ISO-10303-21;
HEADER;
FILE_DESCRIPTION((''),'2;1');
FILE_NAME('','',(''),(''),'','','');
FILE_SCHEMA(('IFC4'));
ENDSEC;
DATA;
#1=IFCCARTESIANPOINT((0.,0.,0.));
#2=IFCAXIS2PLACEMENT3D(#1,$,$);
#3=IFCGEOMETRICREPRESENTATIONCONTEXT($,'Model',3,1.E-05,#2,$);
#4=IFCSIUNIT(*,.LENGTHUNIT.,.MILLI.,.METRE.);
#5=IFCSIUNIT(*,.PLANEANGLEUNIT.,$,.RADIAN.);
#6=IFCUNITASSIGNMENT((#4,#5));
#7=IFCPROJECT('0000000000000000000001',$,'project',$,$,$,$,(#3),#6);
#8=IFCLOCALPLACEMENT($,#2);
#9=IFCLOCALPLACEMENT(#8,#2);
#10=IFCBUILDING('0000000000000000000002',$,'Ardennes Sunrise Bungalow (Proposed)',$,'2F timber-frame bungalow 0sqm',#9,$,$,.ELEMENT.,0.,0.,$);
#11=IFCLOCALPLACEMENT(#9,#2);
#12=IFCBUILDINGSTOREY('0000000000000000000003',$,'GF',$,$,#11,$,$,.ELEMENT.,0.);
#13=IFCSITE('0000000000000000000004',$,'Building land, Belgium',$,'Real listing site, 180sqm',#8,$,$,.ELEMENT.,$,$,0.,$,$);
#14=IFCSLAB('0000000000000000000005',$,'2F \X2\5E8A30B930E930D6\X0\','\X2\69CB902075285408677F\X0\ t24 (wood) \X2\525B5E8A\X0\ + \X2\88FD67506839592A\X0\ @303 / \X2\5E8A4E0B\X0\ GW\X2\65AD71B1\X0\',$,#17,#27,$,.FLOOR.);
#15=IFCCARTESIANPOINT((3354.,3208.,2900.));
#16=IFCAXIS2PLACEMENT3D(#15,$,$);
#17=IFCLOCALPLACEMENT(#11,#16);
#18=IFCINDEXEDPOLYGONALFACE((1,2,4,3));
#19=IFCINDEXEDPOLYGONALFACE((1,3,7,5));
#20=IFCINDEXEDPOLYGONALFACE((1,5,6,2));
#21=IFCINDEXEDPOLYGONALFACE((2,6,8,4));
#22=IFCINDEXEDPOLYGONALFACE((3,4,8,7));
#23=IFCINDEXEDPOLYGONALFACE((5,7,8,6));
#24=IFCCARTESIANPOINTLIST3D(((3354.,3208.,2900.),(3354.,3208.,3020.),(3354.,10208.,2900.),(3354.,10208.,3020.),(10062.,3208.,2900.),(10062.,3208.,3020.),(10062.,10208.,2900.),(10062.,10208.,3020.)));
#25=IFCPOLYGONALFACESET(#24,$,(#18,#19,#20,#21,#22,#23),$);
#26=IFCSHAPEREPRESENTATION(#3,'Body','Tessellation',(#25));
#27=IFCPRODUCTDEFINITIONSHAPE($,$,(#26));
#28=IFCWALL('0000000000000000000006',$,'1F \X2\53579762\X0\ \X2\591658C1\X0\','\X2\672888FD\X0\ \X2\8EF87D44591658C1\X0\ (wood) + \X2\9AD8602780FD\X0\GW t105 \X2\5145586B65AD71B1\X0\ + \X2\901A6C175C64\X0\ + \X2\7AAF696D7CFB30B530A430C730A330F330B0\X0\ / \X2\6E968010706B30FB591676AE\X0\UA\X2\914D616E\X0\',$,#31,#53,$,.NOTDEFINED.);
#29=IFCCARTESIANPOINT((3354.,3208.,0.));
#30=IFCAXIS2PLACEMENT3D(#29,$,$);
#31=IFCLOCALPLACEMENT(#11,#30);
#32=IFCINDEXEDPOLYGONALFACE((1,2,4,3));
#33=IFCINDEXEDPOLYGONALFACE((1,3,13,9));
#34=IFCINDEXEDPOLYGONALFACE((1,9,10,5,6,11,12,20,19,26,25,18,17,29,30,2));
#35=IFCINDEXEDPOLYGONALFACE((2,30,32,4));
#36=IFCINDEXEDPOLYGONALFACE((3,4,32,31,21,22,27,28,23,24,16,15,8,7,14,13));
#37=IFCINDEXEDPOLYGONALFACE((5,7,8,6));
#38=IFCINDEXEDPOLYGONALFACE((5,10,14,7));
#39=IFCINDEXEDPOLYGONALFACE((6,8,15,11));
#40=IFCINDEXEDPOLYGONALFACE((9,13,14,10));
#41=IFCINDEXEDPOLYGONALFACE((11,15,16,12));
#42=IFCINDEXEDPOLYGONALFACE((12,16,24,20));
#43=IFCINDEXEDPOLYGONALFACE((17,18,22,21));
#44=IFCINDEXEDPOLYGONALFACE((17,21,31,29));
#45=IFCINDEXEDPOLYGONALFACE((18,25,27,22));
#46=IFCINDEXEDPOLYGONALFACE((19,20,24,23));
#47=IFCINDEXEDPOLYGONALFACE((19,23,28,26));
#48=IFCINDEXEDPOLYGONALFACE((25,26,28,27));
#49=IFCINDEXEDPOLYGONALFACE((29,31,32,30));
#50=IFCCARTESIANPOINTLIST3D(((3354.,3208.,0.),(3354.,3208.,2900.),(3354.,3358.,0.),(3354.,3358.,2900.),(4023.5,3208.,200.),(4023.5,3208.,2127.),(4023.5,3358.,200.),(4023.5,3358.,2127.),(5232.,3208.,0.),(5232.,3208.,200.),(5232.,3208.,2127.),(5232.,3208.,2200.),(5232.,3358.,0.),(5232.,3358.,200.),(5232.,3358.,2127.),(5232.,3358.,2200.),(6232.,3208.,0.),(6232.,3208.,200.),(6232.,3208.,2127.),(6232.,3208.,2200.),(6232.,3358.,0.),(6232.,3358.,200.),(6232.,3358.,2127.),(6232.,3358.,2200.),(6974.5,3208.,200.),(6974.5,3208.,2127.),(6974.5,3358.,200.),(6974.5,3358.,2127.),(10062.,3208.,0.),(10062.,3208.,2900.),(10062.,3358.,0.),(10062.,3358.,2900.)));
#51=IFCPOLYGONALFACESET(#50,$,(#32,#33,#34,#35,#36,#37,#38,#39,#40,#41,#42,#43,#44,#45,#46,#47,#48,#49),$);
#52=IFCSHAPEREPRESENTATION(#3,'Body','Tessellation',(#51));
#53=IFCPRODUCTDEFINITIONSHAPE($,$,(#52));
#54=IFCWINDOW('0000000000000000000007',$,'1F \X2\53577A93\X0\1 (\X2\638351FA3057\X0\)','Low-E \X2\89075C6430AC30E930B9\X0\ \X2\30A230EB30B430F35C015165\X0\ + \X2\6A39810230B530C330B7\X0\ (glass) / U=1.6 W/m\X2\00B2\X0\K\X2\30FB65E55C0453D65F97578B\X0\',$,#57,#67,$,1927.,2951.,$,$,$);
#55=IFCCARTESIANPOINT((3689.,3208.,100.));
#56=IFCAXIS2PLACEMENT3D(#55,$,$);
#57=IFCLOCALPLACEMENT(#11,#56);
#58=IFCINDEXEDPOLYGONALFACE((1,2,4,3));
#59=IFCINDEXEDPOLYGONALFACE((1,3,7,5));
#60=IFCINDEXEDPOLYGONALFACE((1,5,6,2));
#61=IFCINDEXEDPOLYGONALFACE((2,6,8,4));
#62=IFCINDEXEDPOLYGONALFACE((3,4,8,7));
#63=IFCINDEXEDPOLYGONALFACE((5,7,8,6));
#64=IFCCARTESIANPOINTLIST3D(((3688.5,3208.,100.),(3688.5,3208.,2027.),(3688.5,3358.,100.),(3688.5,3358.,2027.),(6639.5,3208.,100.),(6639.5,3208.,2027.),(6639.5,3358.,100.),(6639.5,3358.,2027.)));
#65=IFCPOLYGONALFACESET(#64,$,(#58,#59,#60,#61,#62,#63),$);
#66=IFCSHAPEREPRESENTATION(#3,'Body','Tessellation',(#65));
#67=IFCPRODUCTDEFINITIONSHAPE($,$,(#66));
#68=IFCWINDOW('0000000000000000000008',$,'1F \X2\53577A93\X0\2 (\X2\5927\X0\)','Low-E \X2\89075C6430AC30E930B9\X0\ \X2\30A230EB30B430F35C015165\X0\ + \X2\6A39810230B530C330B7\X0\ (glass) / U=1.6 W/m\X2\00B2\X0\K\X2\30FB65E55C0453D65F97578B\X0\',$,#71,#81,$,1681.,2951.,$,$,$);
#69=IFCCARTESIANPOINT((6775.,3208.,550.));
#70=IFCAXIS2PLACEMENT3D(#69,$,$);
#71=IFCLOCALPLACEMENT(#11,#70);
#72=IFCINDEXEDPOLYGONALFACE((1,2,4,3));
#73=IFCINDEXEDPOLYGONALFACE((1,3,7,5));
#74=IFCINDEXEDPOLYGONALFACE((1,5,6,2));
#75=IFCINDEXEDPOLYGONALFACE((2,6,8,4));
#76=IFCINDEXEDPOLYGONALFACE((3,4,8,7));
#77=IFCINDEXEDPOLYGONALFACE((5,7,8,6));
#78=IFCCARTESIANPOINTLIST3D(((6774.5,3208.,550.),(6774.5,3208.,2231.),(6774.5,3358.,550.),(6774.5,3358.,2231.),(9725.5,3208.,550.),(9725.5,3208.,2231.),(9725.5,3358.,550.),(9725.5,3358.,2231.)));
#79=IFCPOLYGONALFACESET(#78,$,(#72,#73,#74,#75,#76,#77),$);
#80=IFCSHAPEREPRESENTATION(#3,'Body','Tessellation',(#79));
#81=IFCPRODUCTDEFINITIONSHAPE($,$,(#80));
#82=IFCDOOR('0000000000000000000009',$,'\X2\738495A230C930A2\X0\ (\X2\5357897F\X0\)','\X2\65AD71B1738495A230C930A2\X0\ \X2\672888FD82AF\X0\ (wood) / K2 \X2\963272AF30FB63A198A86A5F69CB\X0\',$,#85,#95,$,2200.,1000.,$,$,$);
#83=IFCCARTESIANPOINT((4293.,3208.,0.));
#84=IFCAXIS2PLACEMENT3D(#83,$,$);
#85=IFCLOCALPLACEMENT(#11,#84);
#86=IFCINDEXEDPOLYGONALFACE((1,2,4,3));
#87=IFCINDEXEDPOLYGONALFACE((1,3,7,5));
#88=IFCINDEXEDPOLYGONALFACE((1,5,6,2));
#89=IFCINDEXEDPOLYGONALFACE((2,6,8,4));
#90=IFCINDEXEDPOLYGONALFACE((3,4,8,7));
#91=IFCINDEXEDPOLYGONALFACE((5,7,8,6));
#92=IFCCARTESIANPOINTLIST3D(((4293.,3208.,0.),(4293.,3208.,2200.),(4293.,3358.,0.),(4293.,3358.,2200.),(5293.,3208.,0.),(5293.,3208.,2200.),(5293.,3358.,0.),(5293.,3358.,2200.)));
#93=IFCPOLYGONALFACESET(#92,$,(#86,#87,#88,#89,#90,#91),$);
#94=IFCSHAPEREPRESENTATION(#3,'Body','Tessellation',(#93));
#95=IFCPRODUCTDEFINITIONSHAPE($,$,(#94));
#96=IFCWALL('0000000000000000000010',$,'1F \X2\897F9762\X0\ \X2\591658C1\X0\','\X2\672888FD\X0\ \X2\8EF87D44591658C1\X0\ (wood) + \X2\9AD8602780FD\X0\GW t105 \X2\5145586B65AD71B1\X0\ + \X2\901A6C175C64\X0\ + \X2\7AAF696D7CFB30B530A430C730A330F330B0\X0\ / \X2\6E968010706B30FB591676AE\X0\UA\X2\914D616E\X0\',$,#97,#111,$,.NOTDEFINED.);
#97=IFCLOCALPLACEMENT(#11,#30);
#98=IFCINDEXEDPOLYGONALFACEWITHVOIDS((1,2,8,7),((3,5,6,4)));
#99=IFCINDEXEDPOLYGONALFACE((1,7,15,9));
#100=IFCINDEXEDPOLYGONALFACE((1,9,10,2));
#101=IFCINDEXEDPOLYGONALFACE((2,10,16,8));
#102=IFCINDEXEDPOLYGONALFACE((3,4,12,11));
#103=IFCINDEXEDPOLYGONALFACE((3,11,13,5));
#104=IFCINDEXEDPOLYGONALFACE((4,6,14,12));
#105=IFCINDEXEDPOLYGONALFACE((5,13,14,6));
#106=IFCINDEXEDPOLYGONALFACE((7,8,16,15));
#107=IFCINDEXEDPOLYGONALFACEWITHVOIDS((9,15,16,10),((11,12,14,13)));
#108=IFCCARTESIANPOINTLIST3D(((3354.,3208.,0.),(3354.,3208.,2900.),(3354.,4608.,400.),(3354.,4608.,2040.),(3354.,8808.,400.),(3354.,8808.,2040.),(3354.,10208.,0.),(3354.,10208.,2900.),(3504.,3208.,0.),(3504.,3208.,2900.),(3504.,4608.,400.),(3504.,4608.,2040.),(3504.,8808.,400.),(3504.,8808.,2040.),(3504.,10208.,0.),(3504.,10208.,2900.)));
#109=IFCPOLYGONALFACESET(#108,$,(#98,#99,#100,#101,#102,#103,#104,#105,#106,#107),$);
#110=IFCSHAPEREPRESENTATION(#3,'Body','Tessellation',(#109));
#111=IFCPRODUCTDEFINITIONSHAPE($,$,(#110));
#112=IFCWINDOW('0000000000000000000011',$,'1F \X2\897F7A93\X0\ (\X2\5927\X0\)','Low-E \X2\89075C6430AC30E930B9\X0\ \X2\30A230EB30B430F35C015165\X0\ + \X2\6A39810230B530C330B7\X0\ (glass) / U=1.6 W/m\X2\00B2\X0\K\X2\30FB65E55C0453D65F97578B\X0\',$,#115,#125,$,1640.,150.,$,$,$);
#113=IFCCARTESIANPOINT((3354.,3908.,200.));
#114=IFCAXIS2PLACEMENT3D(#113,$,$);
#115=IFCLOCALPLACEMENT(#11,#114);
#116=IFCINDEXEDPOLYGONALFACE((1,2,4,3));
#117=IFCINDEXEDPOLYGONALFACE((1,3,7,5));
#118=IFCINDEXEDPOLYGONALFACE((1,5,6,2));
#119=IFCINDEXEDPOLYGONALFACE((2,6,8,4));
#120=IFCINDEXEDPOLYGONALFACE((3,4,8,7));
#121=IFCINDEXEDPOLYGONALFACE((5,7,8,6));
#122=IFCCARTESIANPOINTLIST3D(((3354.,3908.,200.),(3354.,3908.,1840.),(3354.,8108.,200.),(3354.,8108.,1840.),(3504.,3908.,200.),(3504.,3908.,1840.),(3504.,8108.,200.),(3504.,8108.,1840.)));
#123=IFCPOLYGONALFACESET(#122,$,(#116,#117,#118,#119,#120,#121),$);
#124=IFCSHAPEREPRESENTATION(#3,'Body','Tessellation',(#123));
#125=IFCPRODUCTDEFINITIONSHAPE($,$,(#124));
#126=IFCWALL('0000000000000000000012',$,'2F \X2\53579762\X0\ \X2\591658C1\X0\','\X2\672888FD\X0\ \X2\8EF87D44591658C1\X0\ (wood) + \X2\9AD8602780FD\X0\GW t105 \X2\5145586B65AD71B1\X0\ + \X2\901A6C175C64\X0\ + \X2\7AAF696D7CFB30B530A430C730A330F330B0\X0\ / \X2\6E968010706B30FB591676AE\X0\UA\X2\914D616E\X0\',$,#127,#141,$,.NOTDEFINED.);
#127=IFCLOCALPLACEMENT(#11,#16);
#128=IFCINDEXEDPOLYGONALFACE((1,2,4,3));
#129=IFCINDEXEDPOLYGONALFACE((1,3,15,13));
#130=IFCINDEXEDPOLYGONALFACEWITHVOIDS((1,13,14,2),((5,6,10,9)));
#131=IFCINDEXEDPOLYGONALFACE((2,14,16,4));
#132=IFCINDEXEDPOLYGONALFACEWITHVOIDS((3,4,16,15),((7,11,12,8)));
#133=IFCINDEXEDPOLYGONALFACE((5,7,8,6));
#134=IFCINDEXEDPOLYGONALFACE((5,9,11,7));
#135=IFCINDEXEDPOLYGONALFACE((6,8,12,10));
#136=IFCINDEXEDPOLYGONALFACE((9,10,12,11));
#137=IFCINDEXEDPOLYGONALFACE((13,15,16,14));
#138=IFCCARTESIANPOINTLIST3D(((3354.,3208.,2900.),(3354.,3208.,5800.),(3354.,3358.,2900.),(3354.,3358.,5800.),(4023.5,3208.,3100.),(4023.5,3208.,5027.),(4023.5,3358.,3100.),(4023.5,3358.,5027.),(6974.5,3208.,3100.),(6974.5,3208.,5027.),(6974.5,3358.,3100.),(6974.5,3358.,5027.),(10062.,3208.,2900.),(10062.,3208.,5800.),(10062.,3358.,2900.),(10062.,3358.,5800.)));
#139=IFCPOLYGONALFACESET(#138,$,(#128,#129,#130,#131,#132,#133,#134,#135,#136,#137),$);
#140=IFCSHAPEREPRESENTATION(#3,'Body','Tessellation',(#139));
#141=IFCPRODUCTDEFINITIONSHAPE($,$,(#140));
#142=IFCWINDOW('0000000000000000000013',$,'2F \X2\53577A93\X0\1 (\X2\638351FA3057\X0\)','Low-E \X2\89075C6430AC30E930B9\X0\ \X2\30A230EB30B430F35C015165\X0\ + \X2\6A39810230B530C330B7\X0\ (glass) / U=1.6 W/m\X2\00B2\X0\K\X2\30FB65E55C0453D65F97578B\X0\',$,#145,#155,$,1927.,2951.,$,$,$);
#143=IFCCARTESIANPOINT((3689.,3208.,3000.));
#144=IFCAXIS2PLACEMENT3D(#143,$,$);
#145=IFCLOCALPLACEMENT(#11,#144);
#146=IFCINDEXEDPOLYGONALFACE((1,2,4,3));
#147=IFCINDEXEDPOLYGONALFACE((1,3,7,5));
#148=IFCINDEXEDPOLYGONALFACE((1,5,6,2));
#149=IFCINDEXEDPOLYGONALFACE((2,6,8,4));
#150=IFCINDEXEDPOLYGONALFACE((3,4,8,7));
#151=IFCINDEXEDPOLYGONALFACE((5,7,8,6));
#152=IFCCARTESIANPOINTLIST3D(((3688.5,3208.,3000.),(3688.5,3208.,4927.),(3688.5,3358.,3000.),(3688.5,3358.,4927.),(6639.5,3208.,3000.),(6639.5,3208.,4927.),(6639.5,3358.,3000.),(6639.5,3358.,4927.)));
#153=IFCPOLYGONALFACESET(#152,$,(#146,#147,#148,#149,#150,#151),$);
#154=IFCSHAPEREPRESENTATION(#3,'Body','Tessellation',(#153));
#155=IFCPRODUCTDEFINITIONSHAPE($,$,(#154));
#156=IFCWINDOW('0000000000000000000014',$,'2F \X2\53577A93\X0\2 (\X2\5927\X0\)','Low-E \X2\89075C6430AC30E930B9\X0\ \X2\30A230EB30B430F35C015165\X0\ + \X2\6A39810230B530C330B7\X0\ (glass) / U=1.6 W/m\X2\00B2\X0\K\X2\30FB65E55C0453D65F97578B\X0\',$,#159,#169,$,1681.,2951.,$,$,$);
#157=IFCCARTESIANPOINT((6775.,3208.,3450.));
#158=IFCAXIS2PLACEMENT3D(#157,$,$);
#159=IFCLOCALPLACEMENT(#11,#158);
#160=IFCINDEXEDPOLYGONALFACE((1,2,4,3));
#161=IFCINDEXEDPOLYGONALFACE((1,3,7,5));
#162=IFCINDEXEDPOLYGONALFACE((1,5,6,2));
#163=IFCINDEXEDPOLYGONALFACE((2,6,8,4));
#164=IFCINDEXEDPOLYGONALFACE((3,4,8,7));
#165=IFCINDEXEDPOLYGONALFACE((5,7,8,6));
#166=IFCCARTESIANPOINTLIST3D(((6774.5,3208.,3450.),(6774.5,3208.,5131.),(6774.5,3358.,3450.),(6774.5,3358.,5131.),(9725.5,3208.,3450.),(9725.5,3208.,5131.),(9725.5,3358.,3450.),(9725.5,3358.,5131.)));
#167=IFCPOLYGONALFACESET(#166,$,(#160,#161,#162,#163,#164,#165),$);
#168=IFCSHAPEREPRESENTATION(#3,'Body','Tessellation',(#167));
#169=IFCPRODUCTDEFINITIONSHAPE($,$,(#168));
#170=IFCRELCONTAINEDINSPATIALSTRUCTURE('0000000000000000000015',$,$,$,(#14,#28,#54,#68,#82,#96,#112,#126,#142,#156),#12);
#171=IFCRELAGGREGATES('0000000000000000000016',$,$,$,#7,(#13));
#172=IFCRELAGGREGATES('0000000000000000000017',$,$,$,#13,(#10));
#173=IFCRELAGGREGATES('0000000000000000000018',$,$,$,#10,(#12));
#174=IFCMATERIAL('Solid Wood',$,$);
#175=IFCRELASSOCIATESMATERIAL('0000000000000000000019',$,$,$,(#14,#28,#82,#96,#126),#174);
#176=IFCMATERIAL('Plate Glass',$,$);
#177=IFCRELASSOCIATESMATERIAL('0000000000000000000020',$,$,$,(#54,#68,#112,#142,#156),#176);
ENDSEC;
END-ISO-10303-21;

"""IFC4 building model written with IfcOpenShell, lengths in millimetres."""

from ifc_helpers import new_model, si_unit, frame, frame_2d, origin, place, context, project, spatial, rectangle, extrude, material, element, fill, save


model = new_model("IFC4")

# Units and contexts
model_context = context("Model", 3, precision=1e-05, world=origin())
ifc_project = project(units=[si_unit("LENGTHUNIT", "METRE", prefix="MILLI"), si_unit("PLANEANGLEUNIT", "RADIAN")], contexts=[model_context])

# Site, building, storey
site_placement = place(None, origin())
site = spatial("IfcSite", under=ifc_project, at=site_placement, Name="Building land, Belgium", ObjectType="Real listing site, 180sqm", CompositionType="ELEMENT", RefElevation=0.0)
building_placement = place(site_placement, origin())
building = spatial("IfcBuilding", under=site, at=building_placement, Name="Ardennes Sunrise Bungalow (Proposed)", ObjectType="2F timber-frame bungalow 0sqm", CompositionType="ELEMENT", ElevationOfRefHeight=0.0, ElevationOfTerrain=0.0)
storey_placement = place(building_placement, origin())
storey = spatial("IfcBuildingStorey", under=building, at=storey_placement, Name="GF", CompositionType="ELEMENT", Elevation=0.0)

# Slab
ifc_material_1 = material(Name="Solid Wood")
slab_1_placement = place(storey_placement, frame((3354.0, 3208.0, 2900.0)))
element("IfcSlab", 1, at=slab_1_placement, inside=storey, material=ifc_material_1, Name="2F 床スラブ", Description="構造用合板 t24 (wood) 剛床 + 製材根太 @303 / 床下 GW断熱", PredefinedType="FLOOR", context=model_context, shape_type="SweptSolid", body=[
    extrude(rectangle(XDim=6708.0, YDim=7000.0, at=frame_2d((3354.0, 3500.0))), frame((3354.0, 3208.0, 2900.0)), (0.0, 0.0, 1.0), 120.0),
])

# Wall, openings, windows, door
wall_1_placement = place(storey_placement, frame((3354.0, 3208.0, 0.0)))
wall_1 = element("IfcWall", 2, at=wall_1_placement, inside=storey, material=ifc_material_1, Name="1F 南面 外壁", Description="木製 軸組外壁 (wood) + 高性能GW t105 充填断熱 + 通気層 + 窯業系サイディング / 準耐火・外皮UA配慮", PredefinedType="NOTDEFINED", context=model_context, shape_type="SweptSolid", body=[
    extrude(rectangle(XDim=6708.0, YDim=150.0, at=frame_2d((3354.0, 75.0))), frame((3354.0, 3208.0, 0.0)), (0.0, 0.0, 1.0), 2900.0),
])
opening_1_placement = place(storey_placement, frame((3689.0, 3208.0, 100.0)))
opening_1 = element("IfcOpeningElement", 3, at=opening_1_placement, cuts=wall_1, PredefinedType="NOTDEFINED", context=model_context, shape_type="SweptSolid", body=[
    extrude(rectangle(XDim=2951.0, YDim=150.0, at=frame_2d((1475.0, 75.0))), frame((3689.0, 3208.0, 100.0)), (0.0, 0.0, 1.0), 1927.0),
])
opening_2_placement = place(storey_placement, frame((6775.0, 3208.0, 550.0)))
opening_2 = element("IfcOpeningElement", 4, at=opening_2_placement, cuts=wall_1, PredefinedType="NOTDEFINED", context=model_context, shape_type="SweptSolid", body=[
    extrude(rectangle(XDim=2951.0, YDim=150.0, at=frame_2d((1475.0, 75.0))), frame((6775.0, 3208.0, 550.0)), (0.0, 0.0, 1.0), 1681.0),
])
opening_3_placement = place(storey_placement, frame((4293.0, 3208.0, 0.0)))
opening_3 = element("IfcOpeningElement", 5, at=opening_3_placement, cuts=wall_1, PredefinedType="NOTDEFINED", context=model_context, shape_type="SweptSolid", body=[
    extrude(rectangle(XDim=1000.0, YDim=150.0, at=frame_2d((500.0, 75.0))), frame((4293.0, 3208.0, 0.0)), (0.0, 0.0, 1.0), 2200.0),
])
ifc_material_2 = material(Name="Plate Glass")
window_1_placement = place(storey_placement, frame((3689.0, 3208.0, 100.0)))
window_1 = element("IfcWindow", 6, at=window_1_placement, inside=storey, material=ifc_material_2, Name="1F 南窓1 (掃出し)", Description="Low-E 複層ガラス アルゴン封入 + 樹脂サッシ (glass) / U=1.6 W/m²K・日射取得型", OverallHeight=1927.0, OverallWidth=2951.0, context=model_context, shape_type="SweptSolid", body=[
    extrude(rectangle(XDim=2951.0, YDim=150.0, at=frame_2d((1475.0, 75.0))), frame((3689.0, 3208.0, 100.0)), (0.0, 0.0, 1.0), 1927.0),
])
fill(opening_1, window_1)
window_2_placement = place(storey_placement, frame((6775.0, 3208.0, 550.0)))
window_2 = element("IfcWindow", 7, at=window_2_placement, inside=storey, material=ifc_material_2, Name="1F 南窓2 (大)", Description="Low-E 複層ガラス アルゴン封入 + 樹脂サッシ (glass) / U=1.6 W/m²K・日射取得型", OverallHeight=1681.0, OverallWidth=2951.0, context=model_context, shape_type="SweptSolid", body=[
    extrude(rectangle(XDim=2951.0, YDim=150.0, at=frame_2d((1475.0, 75.0))), frame((6775.0, 3208.0, 550.0)), (0.0, 0.0, 1.0), 1681.0),
])
fill(opening_2, window_2)
door_placement = place(storey_placement, frame((4293.0, 3208.0, 0.0)))
door = element("IfcDoor", 8, at=door_placement, inside=storey, material=ifc_material_1, Name="玄関ドア (南西)", Description="断熱玄関ドア 木製芯 (wood) / K2 防犯・採風機構", OverallHeight=2200.0, OverallWidth=1000.0, context=model_context, shape_type="SweptSolid", body=[
    extrude(rectangle(XDim=1000.0, YDim=150.0, at=frame_2d((500.0, 75.0))), frame((4293.0, 3208.0, 0.0)), (0.0, 0.0, 1.0), 2200.0),
])
fill(opening_3, door)

# Wall, opening, window
wall_2_placement = place(storey_placement, frame((3354.0, 3208.0, 0.0)))
wall_2 = element("IfcWall", 9, at=wall_2_placement, inside=storey, material=ifc_material_1, Name="1F 西面 外壁", Description="木製 軸組外壁 (wood) + 高性能GW t105 充填断熱 + 通気層 + 窯業系サイディング / 準耐火・外皮UA配慮", PredefinedType="NOTDEFINED", context=model_context, shape_type="SweptSolid", body=[
    extrude(rectangle(XDim=150.0, YDim=7000.0, at=frame_2d((75.0, 3500.0))), frame((3354.0, 3208.0, 0.0)), (0.0, 0.0, 1.0), 2900.0),
])
opening_4_placement = place(storey_placement, frame((3354.0, 3908.0, 200.0)))
opening_4 = element("IfcOpeningElement", 10, at=opening_4_placement, cuts=wall_2, PredefinedType="NOTDEFINED", context=model_context, shape_type="SweptSolid", body=[
    extrude(rectangle(XDim=150.0, YDim=4200.0, at=frame_2d((75.0, 2100.0))), frame((3354.0, 3908.0, 200.0)), (0.0, 0.0, 1.0), 1640.0),
])
window_3_placement = place(storey_placement, frame((3354.0, 3908.0, 200.0)))
window_3 = element("IfcWindow", 11, at=window_3_placement, inside=storey, material=ifc_material_2, Name="1F 西窓 (大)", Description="Low-E 複層ガラス アルゴン封入 + 樹脂サッシ (glass) / U=1.6 W/m²K・日射取得型", OverallHeight=1640.0, OverallWidth=150.0, context=model_context, shape_type="SweptSolid", body=[
    extrude(rectangle(XDim=150.0, YDim=4200.0, at=frame_2d((75.0, 2100.0))), frame((3354.0, 3908.0, 200.0)), (0.0, 0.0, 1.0), 1640.0),
])
fill(opening_4, window_3)

# Wall, openings, windows
wall_3_placement = place(storey_placement, frame((3354.0, 3208.0, 2900.0)))
wall_3 = element("IfcWall", 12, at=wall_3_placement, inside=storey, material=ifc_material_1, Name="2F 南面 外壁", Description="木製 軸組外壁 (wood) + 高性能GW t105 充填断熱 + 通気層 + 窯業系サイディング / 準耐火・外皮UA配慮", PredefinedType="NOTDEFINED", context=model_context, shape_type="SweptSolid", body=[
    extrude(rectangle(XDim=6708.0, YDim=150.0, at=frame_2d((3354.0, 75.0))), frame((3354.0, 3208.0, 2900.0)), (0.0, 0.0, 1.0), 2900.0),
])
opening_5_placement = place(storey_placement, frame((3689.0, 3208.0, 3000.0)))
opening_5 = element("IfcOpeningElement", 13, at=opening_5_placement, cuts=wall_3, PredefinedType="NOTDEFINED", context=model_context, shape_type="SweptSolid", body=[
    extrude(rectangle(XDim=2951.0, YDim=150.0, at=frame_2d((1475.0, 75.0))), frame((3689.0, 3208.0, 3000.0)), (0.0, 0.0, 1.0), 1927.0),
])
opening_6_placement = place(storey_placement, frame((6775.0, 3208.0, 3450.0)))
opening_6 = element("IfcOpeningElement", 14, at=opening_6_placement, cuts=wall_3, PredefinedType="NOTDEFINED", context=model_context, shape_type="SweptSolid", body=[
    extrude(rectangle(XDim=2951.0, YDim=150.0, at=frame_2d((1475.0, 75.0))), frame((6775.0, 3208.0, 3450.0)), (0.0, 0.0, 1.0), 1681.0),
])
window_4_placement = place(storey_placement, frame((3689.0, 3208.0, 3000.0)))
window_4 = element("IfcWindow", 15, at=window_4_placement, inside=storey, material=ifc_material_2, Name="2F 南窓1 (掃出し)", Description="Low-E 複層ガラス アルゴン封入 + 樹脂サッシ (glass) / U=1.6 W/m²K・日射取得型", OverallHeight=1927.0, OverallWidth=2951.0, context=model_context, shape_type="SweptSolid", body=[
    extrude(rectangle(XDim=2951.0, YDim=150.0, at=frame_2d((1475.0, 75.0))), frame((3689.0, 3208.0, 3000.0)), (0.0, 0.0, 1.0), 1927.0),
])
fill(opening_5, window_4)
window_5_placement = place(storey_placement, frame((6775.0, 3208.0, 3450.0)))
window_5 = element("IfcWindow", 16, at=window_5_placement, inside=storey, material=ifc_material_2, Name="2F 南窓2 (大)", Description="Low-E 複層ガラス アルゴン封入 + 樹脂サッシ (glass) / U=1.6 W/m²K・日射取得型", OverallHeight=1681.0, OverallWidth=2951.0, context=model_context, shape_type="SweptSolid", body=[
    extrude(rectangle(XDim=2951.0, YDim=150.0, at=frame_2d((1475.0, 75.0))), frame((6775.0, 3208.0, 3450.0)), (0.0, 0.0, 1.0), 1681.0),
])
fill(opening_6, window_5)

save(model, "model.ifc")
